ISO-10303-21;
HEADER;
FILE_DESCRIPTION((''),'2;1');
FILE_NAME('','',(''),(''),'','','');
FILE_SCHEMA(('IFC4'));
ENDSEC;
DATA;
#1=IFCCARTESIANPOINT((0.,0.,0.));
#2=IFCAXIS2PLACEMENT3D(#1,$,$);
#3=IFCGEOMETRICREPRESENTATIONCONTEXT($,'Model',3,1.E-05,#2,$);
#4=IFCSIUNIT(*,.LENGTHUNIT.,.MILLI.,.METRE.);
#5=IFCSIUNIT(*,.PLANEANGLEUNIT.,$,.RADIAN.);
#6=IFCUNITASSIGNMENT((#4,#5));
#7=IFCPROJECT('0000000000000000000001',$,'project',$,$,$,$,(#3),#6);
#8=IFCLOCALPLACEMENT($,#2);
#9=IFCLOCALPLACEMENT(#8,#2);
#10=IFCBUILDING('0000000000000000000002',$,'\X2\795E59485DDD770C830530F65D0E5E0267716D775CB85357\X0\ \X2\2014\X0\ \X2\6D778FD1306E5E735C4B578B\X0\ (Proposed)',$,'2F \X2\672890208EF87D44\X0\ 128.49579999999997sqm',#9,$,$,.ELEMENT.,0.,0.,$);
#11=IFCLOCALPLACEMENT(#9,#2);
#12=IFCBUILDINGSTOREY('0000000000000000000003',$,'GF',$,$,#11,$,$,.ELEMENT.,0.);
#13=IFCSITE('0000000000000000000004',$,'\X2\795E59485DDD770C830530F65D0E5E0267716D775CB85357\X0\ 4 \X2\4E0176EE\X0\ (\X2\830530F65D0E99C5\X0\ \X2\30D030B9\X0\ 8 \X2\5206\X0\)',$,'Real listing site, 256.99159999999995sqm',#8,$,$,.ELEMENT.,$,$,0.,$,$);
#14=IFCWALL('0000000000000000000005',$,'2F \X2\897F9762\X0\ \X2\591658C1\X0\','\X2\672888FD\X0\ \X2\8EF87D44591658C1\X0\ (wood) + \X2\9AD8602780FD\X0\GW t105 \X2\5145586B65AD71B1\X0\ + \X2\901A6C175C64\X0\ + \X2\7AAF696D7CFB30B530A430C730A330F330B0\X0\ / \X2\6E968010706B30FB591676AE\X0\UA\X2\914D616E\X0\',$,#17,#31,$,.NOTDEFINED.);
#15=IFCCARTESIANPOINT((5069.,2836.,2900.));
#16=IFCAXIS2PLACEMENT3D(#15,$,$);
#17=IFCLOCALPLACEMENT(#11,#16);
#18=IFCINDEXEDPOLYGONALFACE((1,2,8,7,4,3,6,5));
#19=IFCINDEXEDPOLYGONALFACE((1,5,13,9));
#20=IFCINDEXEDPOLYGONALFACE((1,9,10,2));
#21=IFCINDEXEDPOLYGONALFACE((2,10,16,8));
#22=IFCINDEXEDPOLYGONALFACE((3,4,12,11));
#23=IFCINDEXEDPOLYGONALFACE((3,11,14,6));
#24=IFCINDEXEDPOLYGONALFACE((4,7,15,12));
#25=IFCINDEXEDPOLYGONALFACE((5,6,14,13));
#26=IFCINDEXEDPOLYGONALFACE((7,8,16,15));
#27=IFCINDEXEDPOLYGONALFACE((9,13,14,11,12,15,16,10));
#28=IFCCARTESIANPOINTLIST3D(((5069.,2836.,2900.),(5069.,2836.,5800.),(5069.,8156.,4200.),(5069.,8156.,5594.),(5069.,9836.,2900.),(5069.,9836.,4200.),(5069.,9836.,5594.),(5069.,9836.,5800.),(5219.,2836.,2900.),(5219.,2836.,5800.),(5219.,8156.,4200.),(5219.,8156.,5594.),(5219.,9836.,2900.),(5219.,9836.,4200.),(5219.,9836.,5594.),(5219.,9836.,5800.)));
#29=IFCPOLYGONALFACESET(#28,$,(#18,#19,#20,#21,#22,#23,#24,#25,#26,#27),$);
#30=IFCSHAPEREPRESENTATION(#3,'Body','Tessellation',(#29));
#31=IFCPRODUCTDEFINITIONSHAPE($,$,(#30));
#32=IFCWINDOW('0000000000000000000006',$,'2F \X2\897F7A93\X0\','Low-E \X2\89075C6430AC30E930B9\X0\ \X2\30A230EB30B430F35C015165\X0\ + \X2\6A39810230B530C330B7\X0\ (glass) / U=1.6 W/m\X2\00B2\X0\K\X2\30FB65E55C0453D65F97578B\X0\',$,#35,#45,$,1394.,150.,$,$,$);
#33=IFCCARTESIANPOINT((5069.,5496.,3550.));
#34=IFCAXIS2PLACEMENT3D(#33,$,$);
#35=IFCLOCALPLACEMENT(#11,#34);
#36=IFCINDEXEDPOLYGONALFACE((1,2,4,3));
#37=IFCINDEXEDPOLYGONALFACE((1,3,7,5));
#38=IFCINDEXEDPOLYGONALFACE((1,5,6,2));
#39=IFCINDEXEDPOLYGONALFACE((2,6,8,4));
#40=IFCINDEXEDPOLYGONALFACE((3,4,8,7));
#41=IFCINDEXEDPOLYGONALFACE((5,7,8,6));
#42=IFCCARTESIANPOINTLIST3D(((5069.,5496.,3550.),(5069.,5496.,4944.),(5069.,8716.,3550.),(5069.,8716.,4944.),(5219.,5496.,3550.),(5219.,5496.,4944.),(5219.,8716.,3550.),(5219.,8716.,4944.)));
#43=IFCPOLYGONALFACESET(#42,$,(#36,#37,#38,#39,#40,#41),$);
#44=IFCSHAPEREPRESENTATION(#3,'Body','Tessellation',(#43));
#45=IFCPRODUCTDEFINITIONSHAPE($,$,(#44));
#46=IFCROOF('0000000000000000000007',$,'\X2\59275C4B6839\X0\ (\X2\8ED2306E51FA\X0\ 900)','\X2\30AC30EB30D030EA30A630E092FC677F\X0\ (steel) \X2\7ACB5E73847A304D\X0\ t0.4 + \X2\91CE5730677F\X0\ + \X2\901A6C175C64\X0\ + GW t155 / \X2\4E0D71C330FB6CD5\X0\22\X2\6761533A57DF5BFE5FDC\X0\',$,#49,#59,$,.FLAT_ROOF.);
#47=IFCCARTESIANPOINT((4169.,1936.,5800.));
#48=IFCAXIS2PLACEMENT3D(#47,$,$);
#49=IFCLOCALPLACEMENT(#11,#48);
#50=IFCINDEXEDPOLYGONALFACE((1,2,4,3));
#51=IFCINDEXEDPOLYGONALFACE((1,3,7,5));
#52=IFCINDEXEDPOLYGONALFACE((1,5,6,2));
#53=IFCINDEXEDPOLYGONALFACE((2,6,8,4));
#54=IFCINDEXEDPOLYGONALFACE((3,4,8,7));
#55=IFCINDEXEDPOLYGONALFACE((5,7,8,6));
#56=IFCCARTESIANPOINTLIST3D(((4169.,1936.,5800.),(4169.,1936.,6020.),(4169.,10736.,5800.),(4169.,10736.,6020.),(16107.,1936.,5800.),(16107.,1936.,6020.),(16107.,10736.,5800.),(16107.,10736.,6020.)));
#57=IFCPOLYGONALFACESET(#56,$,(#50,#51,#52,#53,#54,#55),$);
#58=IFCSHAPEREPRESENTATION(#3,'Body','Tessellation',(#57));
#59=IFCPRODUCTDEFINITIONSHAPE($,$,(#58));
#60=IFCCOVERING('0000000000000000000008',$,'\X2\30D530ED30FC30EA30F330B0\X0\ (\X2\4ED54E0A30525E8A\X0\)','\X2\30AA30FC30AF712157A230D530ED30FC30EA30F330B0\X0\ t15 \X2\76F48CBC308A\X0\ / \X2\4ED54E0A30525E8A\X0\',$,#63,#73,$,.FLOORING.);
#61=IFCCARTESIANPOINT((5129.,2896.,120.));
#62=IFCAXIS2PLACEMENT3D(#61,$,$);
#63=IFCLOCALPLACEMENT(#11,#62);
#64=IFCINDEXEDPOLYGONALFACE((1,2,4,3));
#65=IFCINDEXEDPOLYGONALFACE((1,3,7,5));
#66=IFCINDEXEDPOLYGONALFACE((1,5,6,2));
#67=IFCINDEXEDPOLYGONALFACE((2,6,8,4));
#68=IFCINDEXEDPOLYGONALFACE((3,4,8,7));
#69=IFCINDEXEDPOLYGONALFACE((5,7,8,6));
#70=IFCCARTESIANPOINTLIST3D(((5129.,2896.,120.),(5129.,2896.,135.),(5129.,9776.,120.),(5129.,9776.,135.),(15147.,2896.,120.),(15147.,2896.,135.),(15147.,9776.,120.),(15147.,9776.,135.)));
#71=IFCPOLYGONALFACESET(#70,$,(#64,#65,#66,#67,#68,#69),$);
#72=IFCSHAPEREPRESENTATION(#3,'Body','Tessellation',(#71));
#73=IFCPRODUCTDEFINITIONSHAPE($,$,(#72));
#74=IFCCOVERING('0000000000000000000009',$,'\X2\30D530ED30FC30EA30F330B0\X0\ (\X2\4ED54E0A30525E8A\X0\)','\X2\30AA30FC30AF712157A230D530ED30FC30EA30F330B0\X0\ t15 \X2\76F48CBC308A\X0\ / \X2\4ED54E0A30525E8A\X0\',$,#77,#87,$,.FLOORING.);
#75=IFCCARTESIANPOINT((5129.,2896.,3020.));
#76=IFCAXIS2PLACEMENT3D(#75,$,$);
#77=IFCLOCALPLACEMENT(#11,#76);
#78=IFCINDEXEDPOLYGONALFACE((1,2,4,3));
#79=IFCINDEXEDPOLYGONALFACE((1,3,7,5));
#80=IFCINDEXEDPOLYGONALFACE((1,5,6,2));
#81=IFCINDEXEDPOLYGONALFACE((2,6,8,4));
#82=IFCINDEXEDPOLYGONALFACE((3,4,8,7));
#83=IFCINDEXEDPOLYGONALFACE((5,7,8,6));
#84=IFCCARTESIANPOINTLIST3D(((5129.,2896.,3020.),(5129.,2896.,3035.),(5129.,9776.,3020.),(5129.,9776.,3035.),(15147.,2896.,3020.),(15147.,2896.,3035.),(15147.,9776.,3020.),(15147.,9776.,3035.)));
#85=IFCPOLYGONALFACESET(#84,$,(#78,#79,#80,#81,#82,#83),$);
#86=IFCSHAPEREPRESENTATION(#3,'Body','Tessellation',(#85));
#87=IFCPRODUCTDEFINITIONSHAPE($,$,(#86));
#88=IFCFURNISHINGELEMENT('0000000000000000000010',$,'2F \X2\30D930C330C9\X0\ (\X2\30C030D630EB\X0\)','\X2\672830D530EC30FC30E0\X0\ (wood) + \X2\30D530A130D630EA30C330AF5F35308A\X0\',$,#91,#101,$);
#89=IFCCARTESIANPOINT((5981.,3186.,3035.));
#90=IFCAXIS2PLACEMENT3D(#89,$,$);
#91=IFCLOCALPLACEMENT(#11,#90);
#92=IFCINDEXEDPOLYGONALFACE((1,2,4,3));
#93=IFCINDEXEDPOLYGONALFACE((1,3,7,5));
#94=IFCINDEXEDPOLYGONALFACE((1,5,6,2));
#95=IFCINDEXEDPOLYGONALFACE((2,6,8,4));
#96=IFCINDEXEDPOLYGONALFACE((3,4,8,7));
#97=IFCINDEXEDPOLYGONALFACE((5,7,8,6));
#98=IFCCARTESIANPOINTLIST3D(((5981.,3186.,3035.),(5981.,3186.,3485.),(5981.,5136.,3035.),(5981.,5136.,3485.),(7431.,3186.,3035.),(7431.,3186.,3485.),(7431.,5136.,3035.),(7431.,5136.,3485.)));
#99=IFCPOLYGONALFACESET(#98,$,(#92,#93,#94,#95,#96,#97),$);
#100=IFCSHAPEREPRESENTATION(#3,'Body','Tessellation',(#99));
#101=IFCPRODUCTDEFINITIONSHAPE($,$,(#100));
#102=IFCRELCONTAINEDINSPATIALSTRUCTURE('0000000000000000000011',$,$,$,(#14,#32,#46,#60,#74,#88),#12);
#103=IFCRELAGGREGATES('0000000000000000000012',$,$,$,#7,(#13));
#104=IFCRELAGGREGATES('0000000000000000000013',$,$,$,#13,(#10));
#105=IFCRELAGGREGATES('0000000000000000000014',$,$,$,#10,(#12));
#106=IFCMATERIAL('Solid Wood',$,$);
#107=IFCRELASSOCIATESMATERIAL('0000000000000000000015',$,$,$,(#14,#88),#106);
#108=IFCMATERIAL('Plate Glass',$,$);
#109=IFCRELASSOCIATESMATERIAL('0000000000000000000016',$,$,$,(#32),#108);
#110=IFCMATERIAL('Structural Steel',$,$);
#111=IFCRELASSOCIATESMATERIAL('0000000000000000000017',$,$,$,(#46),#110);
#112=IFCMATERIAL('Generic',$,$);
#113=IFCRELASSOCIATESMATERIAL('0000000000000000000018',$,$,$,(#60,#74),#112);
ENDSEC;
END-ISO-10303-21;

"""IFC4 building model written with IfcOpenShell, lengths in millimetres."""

from ifc_helpers import new_model, si_unit, frame, frame_2d, origin, place, context, project, spatial, rectangle, extrude, material, element, fill, save


model = new_model("IFC4")

# Units and contexts
model_context = context("Model", 3, precision=1e-05, world=origin())
ifc_project = project(units=[si_unit("LENGTHUNIT", "METRE", prefix="MILLI"), si_unit("PLANEANGLEUNIT", "RADIAN")], contexts=[model_context])

# Site, building, storey
site_placement = place(None, origin())
site = spatial("IfcSite", under=ifc_project, at=site_placement, Name="神奈川県茅ヶ崎市東海岸南 4 丁目 (茅ヶ崎駅 バス 8 分)", ObjectType="Real listing site, 256.99159999999995sqm", CompositionType="ELEMENT", RefElevation=0.0)
building_placement = place(site_placement, origin())
building = spatial("IfcBuilding", under=site, at=building_placement, Name="神奈川県茅ヶ崎市東海岸南 — 海近の平屋型 (Proposed)", ObjectType="2F 木造軸組 128.49579999999997sqm", CompositionType="ELEMENT", ElevationOfRefHeight=0.0, ElevationOfTerrain=0.0)
storey_placement = place(building_placement, origin())
storey = spatial("IfcBuildingStorey", under=building, at=storey_placement, Name="GF", CompositionType="ELEMENT", Elevation=0.0)

# Shared definitions
ifc_material_1 = material(Name="Solid Wood")

# Shared definitions
ifc_material_2 = material(Name="Plate Glass")

# Wall, opening, window
wall_1_placement = place(storey_placement, frame((5069.0, 2836.0, 2900.0)))
wall_1 = element("IfcWall", 1, at=wall_1_placement, inside=storey, material=ifc_material_1, Name="2F 西面 外壁", Description="木製 軸組外壁 (wood) + 高性能GW t105 充填断熱 + 通気層 + 窯業系サイディング / 準耐火・外皮UA配慮", PredefinedType="NOTDEFINED", context=model_context, shape_type="SweptSolid", body=[
    extrude(rectangle(XDim=150.0, YDim=7000.0, at=frame_2d((75.0, 3500.0))), frame((5069.0, 2836.0, 2900.0)), (0.0, 0.0, 1.0), 2900.0),
])
opening_1_placement = place(storey_placement, frame((5069.0, 5496.0, 3550.0)))
opening_1 = element("IfcOpeningElement", 2, at=opening_1_placement, cuts=wall_1, PredefinedType="NOTDEFINED", context=model_context, shape_type="SweptSolid", body=[
    extrude(rectangle(XDim=150.0, YDim=3220.0, at=frame_2d((75.0, 1610.0))), frame((5069.0, 5496.0, 3550.0)), (0.0, 0.0, 1.0), 1394.0),
])
window_1_placement = place(storey_placement, frame((5069.0, 5496.0, 3550.0)))
window_1 = element("IfcWindow", 3, at=window_1_placement, inside=storey, material=ifc_material_2, Name="2F 西窓", Description="Low-E 複層ガラス アルゴン封入 + 樹脂サッシ (glass) / U=1.6 W/m²K・日射取得型", OverallHeight=1394.0, OverallWidth=150.0, context=model_context, shape_type="SweptSolid", body=[
    extrude(rectangle(XDim=150.0, YDim=3220.0, at=frame_2d((75.0, 1610.0))), frame((5069.0, 5496.0, 3550.0)), (0.0, 0.0, 1.0), 1394.0),
])
fill(opening_1, window_1)

# Roof
ifc_material_3 = material(Name="Structural Steel")
roof_placement = place(storey_placement, frame((4169.0, 1936.0, 5800.0)))
element("IfcRoof", 4, at=roof_placement, inside=storey, material=ifc_material_3, Name="大屋根 (軒の出 900)", Description="ガルバリウム鋼板 (steel) 立平葺き t0.4 + 野地板 + 通気層 + GW t155 / 不燃・法22条区域対応", PredefinedType="FLAT_ROOF", context=model_context, shape_type="SweptSolid", body=[
    extrude(rectangle(XDim=11938.0, YDim=8800.0, at=frame_2d((5969.0, 4400.0))), frame((4169.0, 1936.0, 5800.0)), (0.0, 0.0, 1.0), 220.0),
])

# Coverings
ifc_material_4 = material(Name="Generic")
covering_1_placement = place(storey_placement, frame((5129.0, 2896.0, 120.0)))
element("IfcCovering", 5, at=covering_1_placement, inside=storey, material=ifc_material_4, Name="フローリング (仕上げ床)", Description="オーク無垢フローリング t15 直貼り / 仕上げ床", PredefinedType="FLOORING", context=model_context, shape_type="SweptSolid", body=[
    extrude(rectangle(XDim=10018.0, YDim=6880.0, at=frame_2d((5009.0, 3440.0))), frame((5129.0, 2896.0, 120.0)), (0.0, 0.0, 1.0), 15.0),
])
covering_2_placement = place(storey_placement, frame((5129.0, 2896.0, 3020.0)))
element("IfcCovering", 6, at=covering_2_placement, inside=storey, material=ifc_material_4, Name="フローリング (仕上げ床)", Description="オーク無垢フローリング t15 直貼り / 仕上げ床", PredefinedType="FLOORING", context=model_context, shape_type="SweptSolid", body=[
    extrude(rectangle(XDim=10018.0, YDim=6880.0, at=frame_2d((5009.0, 3440.0))), frame((5129.0, 2896.0, 3020.0)), (0.0, 0.0, 1.0), 15.0),
])

# Furnishing element
furnishing_placement = place(storey_placement, frame((5981.0, 3186.0, 3035.0)))
element("IfcFurnishingElement", 7, at=furnishing_placement, inside=storey, material=ifc_material_1, Name="2F ベッド (ダブル)", Description="木フレーム (wood) + ファブリック張り", context=model_context, shape_type="SweptSolid", body=[
    extrude(rectangle(XDim=1450.0, YDim=1950.0, at=frame_2d((725.0, 975.0))), frame((5981.0, 3186.0, 3035.0)), (0.0, 0.0, 1.0), 450.0),
])

save(model, "model.ifc")
